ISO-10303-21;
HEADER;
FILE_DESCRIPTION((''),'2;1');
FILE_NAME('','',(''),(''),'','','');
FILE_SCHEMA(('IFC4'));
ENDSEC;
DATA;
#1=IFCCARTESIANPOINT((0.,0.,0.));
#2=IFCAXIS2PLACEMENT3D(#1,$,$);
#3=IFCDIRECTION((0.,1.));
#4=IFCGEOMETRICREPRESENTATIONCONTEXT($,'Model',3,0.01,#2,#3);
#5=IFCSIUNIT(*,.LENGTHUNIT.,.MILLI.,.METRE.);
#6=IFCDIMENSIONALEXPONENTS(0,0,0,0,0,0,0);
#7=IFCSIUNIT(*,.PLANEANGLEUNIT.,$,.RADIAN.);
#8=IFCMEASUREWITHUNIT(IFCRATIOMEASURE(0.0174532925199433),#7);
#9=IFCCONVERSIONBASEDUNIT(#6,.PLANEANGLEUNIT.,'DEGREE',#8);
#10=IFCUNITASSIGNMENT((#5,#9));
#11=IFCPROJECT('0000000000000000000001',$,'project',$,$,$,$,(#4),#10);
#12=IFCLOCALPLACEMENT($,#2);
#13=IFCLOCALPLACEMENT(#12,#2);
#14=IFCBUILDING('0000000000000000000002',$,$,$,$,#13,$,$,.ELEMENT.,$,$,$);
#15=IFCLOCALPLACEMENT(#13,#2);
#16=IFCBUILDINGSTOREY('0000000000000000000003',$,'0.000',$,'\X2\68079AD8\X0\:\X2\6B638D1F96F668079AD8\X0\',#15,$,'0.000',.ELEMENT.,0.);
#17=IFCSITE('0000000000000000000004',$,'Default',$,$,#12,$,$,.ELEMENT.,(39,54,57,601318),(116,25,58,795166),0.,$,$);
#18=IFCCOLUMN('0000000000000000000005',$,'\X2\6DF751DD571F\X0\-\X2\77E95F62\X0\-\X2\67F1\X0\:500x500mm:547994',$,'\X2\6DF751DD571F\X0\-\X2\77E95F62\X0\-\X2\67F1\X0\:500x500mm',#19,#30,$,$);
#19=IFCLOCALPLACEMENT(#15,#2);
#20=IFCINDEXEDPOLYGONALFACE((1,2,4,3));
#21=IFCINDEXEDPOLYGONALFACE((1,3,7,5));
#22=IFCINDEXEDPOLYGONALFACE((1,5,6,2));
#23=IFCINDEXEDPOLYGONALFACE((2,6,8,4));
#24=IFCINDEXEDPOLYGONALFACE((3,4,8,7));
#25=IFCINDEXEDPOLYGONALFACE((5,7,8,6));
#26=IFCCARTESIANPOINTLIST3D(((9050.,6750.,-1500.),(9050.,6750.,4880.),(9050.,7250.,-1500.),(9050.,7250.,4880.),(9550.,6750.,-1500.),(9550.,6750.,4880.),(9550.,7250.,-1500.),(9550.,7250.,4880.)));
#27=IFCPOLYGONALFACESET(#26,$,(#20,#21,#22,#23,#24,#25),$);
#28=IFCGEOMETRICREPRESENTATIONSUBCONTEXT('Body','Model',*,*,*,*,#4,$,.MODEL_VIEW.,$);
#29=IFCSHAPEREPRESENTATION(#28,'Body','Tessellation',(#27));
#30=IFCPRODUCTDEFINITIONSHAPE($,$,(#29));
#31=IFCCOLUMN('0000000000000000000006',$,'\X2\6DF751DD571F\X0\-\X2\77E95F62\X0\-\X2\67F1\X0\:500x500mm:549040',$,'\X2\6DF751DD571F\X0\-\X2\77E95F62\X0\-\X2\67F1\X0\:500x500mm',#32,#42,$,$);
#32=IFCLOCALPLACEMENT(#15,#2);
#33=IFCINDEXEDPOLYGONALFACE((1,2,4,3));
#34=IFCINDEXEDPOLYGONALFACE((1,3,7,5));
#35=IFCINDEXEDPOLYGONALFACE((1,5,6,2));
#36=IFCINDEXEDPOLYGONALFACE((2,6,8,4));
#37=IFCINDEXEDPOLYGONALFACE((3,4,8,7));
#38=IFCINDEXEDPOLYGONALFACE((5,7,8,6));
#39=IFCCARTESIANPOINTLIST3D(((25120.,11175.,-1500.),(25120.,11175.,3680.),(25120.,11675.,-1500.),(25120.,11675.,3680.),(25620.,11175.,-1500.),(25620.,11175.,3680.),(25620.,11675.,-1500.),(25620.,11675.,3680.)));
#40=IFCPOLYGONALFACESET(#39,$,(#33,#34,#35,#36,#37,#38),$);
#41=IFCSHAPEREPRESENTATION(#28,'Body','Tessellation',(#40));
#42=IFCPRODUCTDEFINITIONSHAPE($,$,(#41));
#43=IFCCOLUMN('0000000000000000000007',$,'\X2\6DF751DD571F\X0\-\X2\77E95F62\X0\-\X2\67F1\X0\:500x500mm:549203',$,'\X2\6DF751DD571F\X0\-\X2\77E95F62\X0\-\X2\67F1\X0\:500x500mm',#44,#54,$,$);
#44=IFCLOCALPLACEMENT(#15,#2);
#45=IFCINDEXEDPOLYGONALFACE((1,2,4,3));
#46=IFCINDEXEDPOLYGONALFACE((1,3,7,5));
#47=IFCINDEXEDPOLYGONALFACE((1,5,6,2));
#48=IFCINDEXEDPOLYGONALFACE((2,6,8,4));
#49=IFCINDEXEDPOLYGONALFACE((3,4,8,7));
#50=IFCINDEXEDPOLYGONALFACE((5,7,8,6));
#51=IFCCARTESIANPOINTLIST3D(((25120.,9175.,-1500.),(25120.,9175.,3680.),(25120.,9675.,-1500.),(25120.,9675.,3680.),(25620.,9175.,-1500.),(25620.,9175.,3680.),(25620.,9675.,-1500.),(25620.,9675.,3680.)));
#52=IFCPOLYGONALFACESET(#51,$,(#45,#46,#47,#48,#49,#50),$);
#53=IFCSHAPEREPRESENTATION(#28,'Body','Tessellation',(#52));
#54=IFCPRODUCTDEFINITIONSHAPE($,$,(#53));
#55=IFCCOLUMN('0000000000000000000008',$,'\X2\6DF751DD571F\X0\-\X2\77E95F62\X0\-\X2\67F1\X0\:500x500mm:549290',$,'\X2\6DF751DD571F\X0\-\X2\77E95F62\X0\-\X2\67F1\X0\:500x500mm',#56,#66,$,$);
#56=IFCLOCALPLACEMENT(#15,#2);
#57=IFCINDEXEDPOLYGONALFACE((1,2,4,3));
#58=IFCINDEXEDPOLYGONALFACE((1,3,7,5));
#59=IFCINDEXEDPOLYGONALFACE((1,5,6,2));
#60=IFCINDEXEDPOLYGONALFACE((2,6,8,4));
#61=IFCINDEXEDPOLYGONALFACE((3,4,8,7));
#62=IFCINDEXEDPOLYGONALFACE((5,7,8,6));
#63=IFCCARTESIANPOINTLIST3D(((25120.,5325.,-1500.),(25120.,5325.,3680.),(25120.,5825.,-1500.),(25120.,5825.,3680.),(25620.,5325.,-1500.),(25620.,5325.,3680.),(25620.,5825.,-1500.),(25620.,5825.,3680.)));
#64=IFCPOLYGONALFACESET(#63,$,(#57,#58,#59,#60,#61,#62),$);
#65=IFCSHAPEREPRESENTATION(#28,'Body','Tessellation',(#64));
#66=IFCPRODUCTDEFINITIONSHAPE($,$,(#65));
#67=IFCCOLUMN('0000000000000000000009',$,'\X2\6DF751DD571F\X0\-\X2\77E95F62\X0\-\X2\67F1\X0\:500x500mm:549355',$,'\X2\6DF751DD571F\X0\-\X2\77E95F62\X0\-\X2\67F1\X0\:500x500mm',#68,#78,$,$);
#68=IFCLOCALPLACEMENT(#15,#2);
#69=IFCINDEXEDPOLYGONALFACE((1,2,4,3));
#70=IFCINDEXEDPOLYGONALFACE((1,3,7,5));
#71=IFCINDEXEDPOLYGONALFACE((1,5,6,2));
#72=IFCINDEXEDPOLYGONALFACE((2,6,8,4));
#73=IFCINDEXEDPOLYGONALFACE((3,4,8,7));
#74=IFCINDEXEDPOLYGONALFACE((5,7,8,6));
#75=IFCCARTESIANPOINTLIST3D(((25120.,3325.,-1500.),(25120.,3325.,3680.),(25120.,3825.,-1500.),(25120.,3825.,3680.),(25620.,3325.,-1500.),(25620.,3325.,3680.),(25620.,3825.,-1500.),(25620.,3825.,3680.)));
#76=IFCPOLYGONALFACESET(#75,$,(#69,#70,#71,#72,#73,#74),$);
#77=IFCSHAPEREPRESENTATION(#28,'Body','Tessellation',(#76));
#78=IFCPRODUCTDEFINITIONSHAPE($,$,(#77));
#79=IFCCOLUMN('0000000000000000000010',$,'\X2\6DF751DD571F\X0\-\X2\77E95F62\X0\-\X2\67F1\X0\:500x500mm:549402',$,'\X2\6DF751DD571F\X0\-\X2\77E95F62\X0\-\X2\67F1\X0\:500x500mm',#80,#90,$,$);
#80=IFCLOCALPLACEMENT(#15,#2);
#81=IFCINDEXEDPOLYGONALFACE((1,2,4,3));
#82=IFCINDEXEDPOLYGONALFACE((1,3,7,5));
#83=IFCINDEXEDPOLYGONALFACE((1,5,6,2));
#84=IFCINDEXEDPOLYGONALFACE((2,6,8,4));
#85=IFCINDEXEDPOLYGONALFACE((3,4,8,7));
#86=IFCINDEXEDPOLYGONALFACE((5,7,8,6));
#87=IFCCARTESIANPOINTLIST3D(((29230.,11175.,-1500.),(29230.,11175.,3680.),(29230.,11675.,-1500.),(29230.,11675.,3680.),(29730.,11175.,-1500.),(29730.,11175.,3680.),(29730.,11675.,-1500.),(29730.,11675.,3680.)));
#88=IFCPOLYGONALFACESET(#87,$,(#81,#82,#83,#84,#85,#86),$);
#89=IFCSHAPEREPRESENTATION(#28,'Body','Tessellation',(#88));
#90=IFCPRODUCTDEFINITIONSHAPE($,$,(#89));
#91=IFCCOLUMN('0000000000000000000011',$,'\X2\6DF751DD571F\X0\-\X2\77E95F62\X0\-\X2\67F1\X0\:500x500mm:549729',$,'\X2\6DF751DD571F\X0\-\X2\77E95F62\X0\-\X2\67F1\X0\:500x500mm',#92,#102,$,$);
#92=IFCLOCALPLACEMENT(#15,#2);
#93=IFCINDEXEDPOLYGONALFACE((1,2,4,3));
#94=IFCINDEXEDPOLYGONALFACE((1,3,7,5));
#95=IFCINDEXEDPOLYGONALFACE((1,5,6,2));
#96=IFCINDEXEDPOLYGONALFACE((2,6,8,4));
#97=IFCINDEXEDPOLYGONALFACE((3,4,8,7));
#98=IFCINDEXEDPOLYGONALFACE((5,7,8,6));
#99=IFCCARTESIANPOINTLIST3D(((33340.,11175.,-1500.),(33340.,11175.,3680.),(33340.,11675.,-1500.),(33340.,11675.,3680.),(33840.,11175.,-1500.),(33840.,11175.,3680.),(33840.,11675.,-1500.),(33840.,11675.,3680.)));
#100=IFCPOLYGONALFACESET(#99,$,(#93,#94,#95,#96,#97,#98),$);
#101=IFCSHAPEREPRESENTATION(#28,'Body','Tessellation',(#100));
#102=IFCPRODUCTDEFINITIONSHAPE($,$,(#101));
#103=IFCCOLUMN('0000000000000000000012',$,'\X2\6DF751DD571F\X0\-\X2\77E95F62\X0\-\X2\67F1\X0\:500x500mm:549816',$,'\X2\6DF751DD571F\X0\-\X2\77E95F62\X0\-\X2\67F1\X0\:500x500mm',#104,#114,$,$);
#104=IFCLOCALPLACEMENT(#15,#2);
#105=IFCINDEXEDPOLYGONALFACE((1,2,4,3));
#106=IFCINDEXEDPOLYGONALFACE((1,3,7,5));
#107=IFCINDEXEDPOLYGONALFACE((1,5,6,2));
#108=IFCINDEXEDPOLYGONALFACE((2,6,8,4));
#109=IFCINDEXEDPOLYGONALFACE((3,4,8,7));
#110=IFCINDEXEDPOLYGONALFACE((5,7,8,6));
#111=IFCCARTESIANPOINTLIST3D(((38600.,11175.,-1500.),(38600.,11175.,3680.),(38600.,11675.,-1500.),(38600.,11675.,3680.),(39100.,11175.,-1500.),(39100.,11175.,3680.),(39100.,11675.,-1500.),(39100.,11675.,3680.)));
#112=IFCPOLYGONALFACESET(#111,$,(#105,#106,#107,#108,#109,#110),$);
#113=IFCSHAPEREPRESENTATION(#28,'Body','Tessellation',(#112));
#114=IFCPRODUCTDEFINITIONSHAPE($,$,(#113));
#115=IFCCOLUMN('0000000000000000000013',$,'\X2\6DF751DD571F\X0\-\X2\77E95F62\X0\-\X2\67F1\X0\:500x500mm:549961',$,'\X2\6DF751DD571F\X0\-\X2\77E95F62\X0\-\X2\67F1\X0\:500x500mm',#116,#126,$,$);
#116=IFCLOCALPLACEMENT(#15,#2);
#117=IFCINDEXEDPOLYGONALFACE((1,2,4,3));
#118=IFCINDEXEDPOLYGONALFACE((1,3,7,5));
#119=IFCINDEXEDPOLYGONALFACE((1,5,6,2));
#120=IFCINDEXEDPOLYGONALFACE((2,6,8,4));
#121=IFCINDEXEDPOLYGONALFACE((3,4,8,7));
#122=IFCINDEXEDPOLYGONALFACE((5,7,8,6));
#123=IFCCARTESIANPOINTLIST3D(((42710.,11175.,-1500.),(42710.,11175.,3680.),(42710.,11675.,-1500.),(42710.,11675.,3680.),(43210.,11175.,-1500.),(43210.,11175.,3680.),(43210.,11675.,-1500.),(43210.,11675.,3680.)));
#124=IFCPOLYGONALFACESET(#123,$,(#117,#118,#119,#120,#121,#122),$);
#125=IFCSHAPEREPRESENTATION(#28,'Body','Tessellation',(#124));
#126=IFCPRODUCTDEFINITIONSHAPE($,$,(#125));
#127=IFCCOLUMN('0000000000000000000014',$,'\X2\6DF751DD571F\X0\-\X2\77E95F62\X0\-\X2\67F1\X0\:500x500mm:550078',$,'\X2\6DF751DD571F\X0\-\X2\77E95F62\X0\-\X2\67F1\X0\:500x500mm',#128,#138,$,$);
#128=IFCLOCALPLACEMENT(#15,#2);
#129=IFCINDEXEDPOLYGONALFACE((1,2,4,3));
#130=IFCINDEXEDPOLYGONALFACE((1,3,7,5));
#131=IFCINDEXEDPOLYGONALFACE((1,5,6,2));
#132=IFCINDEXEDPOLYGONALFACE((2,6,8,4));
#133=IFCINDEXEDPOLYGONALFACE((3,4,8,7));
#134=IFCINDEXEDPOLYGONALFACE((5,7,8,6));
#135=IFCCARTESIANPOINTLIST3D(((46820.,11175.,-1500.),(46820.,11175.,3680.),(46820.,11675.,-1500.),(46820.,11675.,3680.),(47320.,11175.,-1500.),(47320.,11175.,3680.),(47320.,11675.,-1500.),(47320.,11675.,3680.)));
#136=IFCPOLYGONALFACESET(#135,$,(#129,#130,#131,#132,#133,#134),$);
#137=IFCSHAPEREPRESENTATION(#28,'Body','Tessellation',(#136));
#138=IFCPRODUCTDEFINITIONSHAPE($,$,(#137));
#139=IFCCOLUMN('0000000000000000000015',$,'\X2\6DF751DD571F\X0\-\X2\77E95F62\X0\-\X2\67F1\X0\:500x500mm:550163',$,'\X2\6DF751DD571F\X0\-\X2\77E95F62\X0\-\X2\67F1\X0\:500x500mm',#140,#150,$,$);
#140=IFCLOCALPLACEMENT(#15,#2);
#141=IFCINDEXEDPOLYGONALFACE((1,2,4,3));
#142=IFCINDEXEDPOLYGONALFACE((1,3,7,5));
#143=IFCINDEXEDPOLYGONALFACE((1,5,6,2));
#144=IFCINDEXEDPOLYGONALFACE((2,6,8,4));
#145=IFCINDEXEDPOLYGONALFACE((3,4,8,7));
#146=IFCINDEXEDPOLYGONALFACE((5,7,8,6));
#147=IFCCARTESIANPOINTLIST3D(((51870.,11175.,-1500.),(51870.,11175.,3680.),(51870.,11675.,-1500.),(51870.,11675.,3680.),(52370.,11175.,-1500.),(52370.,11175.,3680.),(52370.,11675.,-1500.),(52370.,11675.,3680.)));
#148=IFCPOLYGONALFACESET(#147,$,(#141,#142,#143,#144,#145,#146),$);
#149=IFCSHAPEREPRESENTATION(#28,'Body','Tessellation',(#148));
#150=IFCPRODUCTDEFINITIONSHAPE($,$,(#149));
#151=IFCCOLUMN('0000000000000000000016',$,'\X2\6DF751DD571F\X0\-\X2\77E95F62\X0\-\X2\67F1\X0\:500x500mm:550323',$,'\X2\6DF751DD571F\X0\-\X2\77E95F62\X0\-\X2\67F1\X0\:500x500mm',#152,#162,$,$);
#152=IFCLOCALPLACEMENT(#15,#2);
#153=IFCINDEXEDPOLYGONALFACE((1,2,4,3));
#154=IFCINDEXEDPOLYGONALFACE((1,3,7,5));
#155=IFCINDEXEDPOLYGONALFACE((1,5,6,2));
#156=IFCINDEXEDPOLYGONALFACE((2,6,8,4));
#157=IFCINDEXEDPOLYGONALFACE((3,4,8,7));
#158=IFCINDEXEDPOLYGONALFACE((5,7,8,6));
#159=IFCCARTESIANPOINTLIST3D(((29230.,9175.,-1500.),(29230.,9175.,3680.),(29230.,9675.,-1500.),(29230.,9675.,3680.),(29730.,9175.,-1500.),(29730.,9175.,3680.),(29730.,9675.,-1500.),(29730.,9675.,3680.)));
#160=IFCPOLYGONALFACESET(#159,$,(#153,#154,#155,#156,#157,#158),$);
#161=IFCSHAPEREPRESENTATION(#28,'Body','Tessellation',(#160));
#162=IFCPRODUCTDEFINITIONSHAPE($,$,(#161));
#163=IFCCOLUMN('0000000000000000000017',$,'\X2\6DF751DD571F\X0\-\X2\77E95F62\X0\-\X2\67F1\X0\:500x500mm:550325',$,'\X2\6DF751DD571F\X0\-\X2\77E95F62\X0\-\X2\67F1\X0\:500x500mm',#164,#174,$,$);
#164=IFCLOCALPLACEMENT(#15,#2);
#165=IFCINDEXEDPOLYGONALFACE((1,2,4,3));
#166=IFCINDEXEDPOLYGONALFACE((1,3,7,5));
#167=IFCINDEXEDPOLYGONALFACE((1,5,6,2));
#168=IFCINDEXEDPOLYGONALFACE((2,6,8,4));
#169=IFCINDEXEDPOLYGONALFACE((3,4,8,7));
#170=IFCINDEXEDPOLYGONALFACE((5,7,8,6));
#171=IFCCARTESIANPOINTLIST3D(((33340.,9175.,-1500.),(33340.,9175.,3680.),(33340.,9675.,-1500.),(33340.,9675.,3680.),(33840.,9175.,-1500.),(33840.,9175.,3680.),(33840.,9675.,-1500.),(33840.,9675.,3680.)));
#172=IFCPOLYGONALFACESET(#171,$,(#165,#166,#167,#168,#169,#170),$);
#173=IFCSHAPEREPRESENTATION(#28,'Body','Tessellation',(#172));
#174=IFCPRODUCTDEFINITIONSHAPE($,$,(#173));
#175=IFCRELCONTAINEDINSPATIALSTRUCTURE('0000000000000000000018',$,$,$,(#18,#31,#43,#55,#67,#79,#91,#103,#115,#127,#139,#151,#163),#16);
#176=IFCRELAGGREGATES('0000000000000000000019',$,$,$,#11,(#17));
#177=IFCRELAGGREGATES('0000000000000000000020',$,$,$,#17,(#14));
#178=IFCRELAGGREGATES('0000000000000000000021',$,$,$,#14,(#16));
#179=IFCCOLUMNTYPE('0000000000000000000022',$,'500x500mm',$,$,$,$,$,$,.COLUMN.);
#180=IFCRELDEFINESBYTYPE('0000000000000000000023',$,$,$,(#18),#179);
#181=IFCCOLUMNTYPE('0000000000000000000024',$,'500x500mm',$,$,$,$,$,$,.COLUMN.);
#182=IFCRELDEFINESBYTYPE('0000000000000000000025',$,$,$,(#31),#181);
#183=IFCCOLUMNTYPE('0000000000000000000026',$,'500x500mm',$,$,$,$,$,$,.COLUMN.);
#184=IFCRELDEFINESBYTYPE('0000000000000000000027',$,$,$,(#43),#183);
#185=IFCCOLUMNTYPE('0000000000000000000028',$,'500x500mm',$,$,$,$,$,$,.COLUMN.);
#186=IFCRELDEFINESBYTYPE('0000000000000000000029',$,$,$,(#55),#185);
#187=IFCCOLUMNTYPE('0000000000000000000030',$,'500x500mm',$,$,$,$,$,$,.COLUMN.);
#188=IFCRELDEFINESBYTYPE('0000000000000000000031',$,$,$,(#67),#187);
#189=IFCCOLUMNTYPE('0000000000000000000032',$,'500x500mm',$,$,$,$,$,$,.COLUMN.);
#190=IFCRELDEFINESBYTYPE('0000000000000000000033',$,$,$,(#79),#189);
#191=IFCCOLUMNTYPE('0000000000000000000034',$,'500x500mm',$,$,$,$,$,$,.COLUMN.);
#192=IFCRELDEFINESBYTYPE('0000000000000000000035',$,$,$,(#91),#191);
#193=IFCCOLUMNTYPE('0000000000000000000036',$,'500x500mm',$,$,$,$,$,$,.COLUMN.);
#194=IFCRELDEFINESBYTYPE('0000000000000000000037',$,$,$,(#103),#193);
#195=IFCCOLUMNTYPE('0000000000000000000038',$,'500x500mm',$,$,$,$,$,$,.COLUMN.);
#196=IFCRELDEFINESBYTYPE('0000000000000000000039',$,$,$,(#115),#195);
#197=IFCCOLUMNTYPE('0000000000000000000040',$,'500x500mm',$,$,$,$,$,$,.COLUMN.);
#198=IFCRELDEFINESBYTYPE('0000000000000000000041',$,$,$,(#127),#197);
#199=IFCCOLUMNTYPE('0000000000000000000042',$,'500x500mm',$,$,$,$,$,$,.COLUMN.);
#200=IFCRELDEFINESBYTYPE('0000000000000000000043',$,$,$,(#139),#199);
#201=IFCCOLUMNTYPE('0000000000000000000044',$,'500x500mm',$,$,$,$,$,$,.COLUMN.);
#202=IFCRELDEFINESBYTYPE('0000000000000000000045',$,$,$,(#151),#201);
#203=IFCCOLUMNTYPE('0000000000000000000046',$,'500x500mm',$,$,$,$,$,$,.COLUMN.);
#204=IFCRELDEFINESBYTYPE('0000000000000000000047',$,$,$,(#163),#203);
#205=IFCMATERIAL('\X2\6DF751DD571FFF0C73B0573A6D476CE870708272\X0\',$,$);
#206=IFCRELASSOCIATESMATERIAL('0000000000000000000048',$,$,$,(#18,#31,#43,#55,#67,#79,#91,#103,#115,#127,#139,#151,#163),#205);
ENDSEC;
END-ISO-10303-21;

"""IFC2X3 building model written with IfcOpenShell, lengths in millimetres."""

from ifc_helpers import new_model, entity, si_unit, converted_unit, direction, frame, frame_2d, origin, origin_2d_with_axis, place, context, subcontext, project, spatial, rectangle, extrude, source, transform, mapped, material, type_object, type_shapes, element, save


model = new_model("IFC2X3")

# Units and contexts
model_context = context("Model", 3, precision=0.01, world=origin(), true_north=direction((0.0, 1.0)))
body_context = subcontext(model_context, "Body", "Model", "MODEL_VIEW")
ifc_project = project(units=[si_unit("LENGTHUNIT", "METRE", prefix="MILLI"), converted_unit("PLANEANGLEUNIT", "DEGREE", entity("IfcRatioMeasure", 0.0174532925199433), si_unit("PLANEANGLEUNIT", "RADIAN"), dimensions=[0, 0, 0, 0, 0, 0, 0])], contexts=[model_context])

# Site, building, storey
site_placement = place(None, origin())
site = spatial("IfcSite", under=ifc_project, at=site_placement, Name="Default", CompositionType="ELEMENT", RefLatitude=(39, 54, 57, 601318), RefLongitude=(116, 25, 58, 795166), RefElevation=0.0)
building_placement = place(site_placement, origin())
building = spatial("IfcBuilding", under=site, at=building_placement, CompositionType="ELEMENT")
storey_placement = place(building_placement, origin())
storey = spatial("IfcBuildingStorey", under=building, at=storey_placement, Name="0.000", ObjectType="标高:正负零标高", LongName="0.000", CompositionType="ELEMENT", Elevation=0.0)

# Columns
ifc_material = material(Name="混凝土，现场浇注灰色")
column_type_1 = type_object("IfcColumnType", Name="500x500mm", PredefinedType="COLUMN")
shared_shape_1 = source(origin(), body_context, "Body", "SweptSolid", [
    extrude(rectangle(XDim=500.0, YDim=500.0, at=frame_2d((0.0, 0.0), x_axis=(1.0, 0.0))), frame((9300.0, 7000.0, -1500.0), z_axis=(0.0, 0.0, 1.0), x_axis=(0.0, -1.0, 0.0)), (0.0, 0.0, 1.0), 6380.0),
])
type_shapes(column_type_1, [shared_shape_1])
column_1_placement = place(storey_placement, origin())
element("IfcColumn", 1, at=column_1_placement, inside=storey, type_object=column_type_1, material=ifc_material, Name="混凝土-矩形-柱:500x500mm:547994", ObjectType="混凝土-矩形-柱:500x500mm", context=body_context, shape_type="MappedRepresentation", body=[
    mapped(shared_shape_1, transform((0.0, 0.0, 0.0), scale=1.0)),
])
column_type_2 = type_object("IfcColumnType", Name="500x500mm", PredefinedType="COLUMN")
shared_shape_2 = source(origin(), body_context, "Body", "SweptSolid", [
    extrude(rectangle(XDim=500.0, YDim=500.0, at=origin_2d_with_axis()), frame((25370.0, 11425.0, -1500.0), z_axis=(0.0, 0.0, 1.0), x_axis=(0.0, -1.0, 0.0)), (0.0, 0.0, 1.0), 5180.0),
])
type_shapes(column_type_2, [shared_shape_2])
column_2_placement = place(storey_placement, origin())
element("IfcColumn", 2, at=column_2_placement, inside=storey, type_object=column_type_2, material=ifc_material, Name="混凝土-矩形-柱:500x500mm:549040", ObjectType="混凝土-矩形-柱:500x500mm", context=body_context, shape_type="MappedRepresentation", body=[
    mapped(shared_shape_2, transform((0.0, 0.0, 0.0), scale=1.0)),
])
column_type_3 = type_object("IfcColumnType", Name="500x500mm", PredefinedType="COLUMN")
shared_shape_3 = source(origin(), body_context, "Body", "SweptSolid", [
    extrude(rectangle(XDim=500.0, YDim=500.0, at=frame_2d((0.0, 0.0), x_axis=(1.0, 0.0))), frame((25370.0, 9425.0, -1500.0), z_axis=(0.0, 0.0, 1.0), x_axis=(0.0, -1.0, 0.0)), (0.0, 0.0, 1.0), 5180.0),
])
type_shapes(column_type_3, [shared_shape_3])
column_3_placement = place(storey_placement, origin())
element("IfcColumn", 3, at=column_3_placement, inside=storey, type_object=column_type_3, material=ifc_material, Name="混凝土-矩形-柱:500x500mm:549203", ObjectType="混凝土-矩形-柱:500x500mm", context=body_context, shape_type="MappedRepresentation", body=[
    mapped(shared_shape_3, transform((0.0, 0.0, 0.0), scale=1.0)),
])
column_type_4 = type_object("IfcColumnType", Name="500x500mm", PredefinedType="COLUMN")
shared_shape_4 = source(origin(), body_context, "Body", "SweptSolid", [
    extrude(rectangle(XDim=500.0, YDim=500.0, at=origin_2d_with_axis()), frame((25370.0, 5575.0, -1500.0), z_axis=(0.0, 0.0, 1.0), x_axis=(0.0, -1.0, 0.0)), (0.0, 0.0, 1.0), 5180.0),
])
type_shapes(column_type_4, [shared_shape_4])
column_4_placement = place(storey_placement, origin())
element("IfcColumn", 4, at=column_4_placement, inside=storey, type_object=column_type_4, material=ifc_material, Name="混凝土-矩形-柱:500x500mm:549290", ObjectType="混凝土-矩形-柱:500x500mm", context=body_context, shape_type="MappedRepresentation", body=[
    mapped(shared_shape_4, transform((0.0, 0.0, 0.0), scale=1.0)),
])
column_type_5 = type_object("IfcColumnType", Name="500x500mm", PredefinedType="COLUMN")
shared_shape_5 = source(origin(), body_context, "Body", "SweptSolid", [
    extrude(rectangle(XDim=500.0, YDim=500.0, at=origin_2d_with_axis()), frame((25370.0, 3575.0, -1500.0), z_axis=(0.0, 0.0, 1.0), x_axis=(0.0, -1.0, 0.0)), (0.0, 0.0, 1.0), 5180.0),
])
type_shapes(column_type_5, [shared_shape_5])
column_5_placement = place(storey_placement, origin())
element("IfcColumn", 5, at=column_5_placement, inside=storey, type_object=column_type_5, material=ifc_material, Name="混凝土-矩形-柱:500x500mm:549355", ObjectType="混凝土-矩形-柱:500x500mm", context=body_context, shape_type="MappedRepresentation", body=[
    mapped(shared_shape_5, transform((0.0, 0.0, 0.0), scale=1.0)),
])
column_type_6 = type_object("IfcColumnType", Name="500x500mm", PredefinedType="COLUMN")
shared_shape_6 = source(origin(), body_context, "Body", "SweptSolid", [
    extrude(rectangle(XDim=500.0, YDim=500.0, at=origin_2d_with_axis()), frame((29480.0, 11425.0, -1500.0), z_axis=(0.0, 0.0, 1.0), x_axis=(0.0, -1.0, 0.0)), (0.0, 0.0, 1.0), 5180.0),
])
type_shapes(column_type_6, [shared_shape_6])
column_6_placement = place(storey_placement, origin())
element("IfcColumn", 6, at=column_6_placement, inside=storey, type_object=column_type_6, material=ifc_material, Name="混凝土-矩形-柱:500x500mm:549402", ObjectType="混凝土-矩形-柱:500x500mm", context=body_context, shape_type="MappedRepresentation", body=[
    mapped(shared_shape_6, transform((0.0, 0.0, 0.0), scale=1.0)),
])
column_type_7 = type_object("IfcColumnType", Name="500x500mm", PredefinedType="COLUMN")
shared_shape_7 = source(origin(), body_context, "Body", "SweptSolid", [
    extrude(rectangle(XDim=500.0, YDim=500.0, at=origin_2d_with_axis()), frame((33590.0, 11425.0, -1500.0), z_axis=(0.0, 0.0, 1.0), x_axis=(0.0, -1.0, 0.0)), (0.0, 0.0, 1.0), 5180.0),
])
type_shapes(column_type_7, [shared_shape_7])
column_7_placement = place(storey_placement, origin())
element("IfcColumn", 7, at=column_7_placement, inside=storey, type_object=column_type_7, material=ifc_material, Name="混凝土-矩形-柱:500x500mm:549729", ObjectType="混凝土-矩形-柱:500x500mm", context=body_context, shape_type="MappedRepresentation", body=[
    mapped(shared_shape_7, transform((0.0, 0.0, 0.0), scale=1.0)),
])
column_type_8 = type_object("IfcColumnType", Name="500x500mm", PredefinedType="COLUMN")
shared_shape_8 = source(origin(), body_context, "Body", "SweptSolid", [
    extrude(rectangle(XDim=500.0, YDim=500.0, at=frame_2d((0.0, 0.0), x_axis=(1.0, 0.0))), frame((38850.0, 11425.0, -1500.0), z_axis=(0.0, 0.0, 1.0), x_axis=(0.0, -1.0, 0.0)), (0.0, 0.0, 1.0), 5180.0),
])
type_shapes(column_type_8, [shared_shape_8])
column_8_placement = place(storey_placement, origin())
element("IfcColumn", 8, at=column_8_placement, inside=storey, type_object=column_type_8, material=ifc_material, Name="混凝土-矩形-柱:500x500mm:549816", ObjectType="混凝土-矩形-柱:500x500mm", context=body_context, shape_type="MappedRepresentation", body=[
    mapped(shared_shape_8, transform((0.0, 0.0, 0.0), scale=1.0)),
])
column_type_9 = type_object("IfcColumnType", Name="500x500mm", PredefinedType="COLUMN")
shared_shape_9 = source(origin(), body_context, "Body", "SweptSolid", [
    extrude(rectangle(XDim=500.0, YDim=500.0, at=origin_2d_with_axis()), frame((42960.0, 11425.0, -1500.0), z_axis=(0.0, 0.0, 1.0), x_axis=(0.0, -1.0, 0.0)), (0.0, 0.0, 1.0), 5180.0),
])
type_shapes(column_type_9, [shared_shape_9])
column_9_placement = place(storey_placement, origin())
element("IfcColumn", 9, at=column_9_placement, inside=storey, type_object=column_type_9, material=ifc_material, Name="混凝土-矩形-柱:500x500mm:549961", ObjectType="混凝土-矩形-柱:500x500mm", context=body_context, shape_type="MappedRepresentation", body=[
    mapped(shared_shape_9, transform((0.0, 0.0, 0.0), scale=1.0)),
])
column_type_10 = type_object("IfcColumnType", Name="500x500mm", PredefinedType="COLUMN")
shared_shape_10 = source(origin(), body_context, "Body", "SweptSolid", [
    extrude(rectangle(XDim=500.0, YDim=500.0, at=origin_2d_with_axis()), frame((47070.0, 11425.0, -1500.0), z_axis=(0.0, 0.0, 1.0), x_axis=(0.0, -1.0, 0.0)), (0.0, 0.0, 1.0), 5180.0),
])
type_shapes(column_type_10, [shared_shape_10])
column_10_placement = place(storey_placement, origin())
element("IfcColumn", 10, at=column_10_placement, inside=storey, type_object=column_type_10, material=ifc_material, Name="混凝土-矩形-柱:500x500mm:550078", ObjectType="混凝土-矩形-柱:500x500mm", context=body_context, shape_type="MappedRepresentation", body=[
    mapped(shared_shape_10, transform((0.0, 0.0, 0.0), scale=1.0)),
])
column_type_11 = type_object("IfcColumnType", Name="500x500mm", PredefinedType="COLUMN")
shared_shape_11 = source(origin(), body_context, "Body", "SweptSolid", [
    extrude(rectangle(XDim=500.0, YDim=500.0, at=frame_2d((0.0, 0.0), x_axis=(1.0, 0.0))), frame((52120.0, 11425.0, -1500.0), z_axis=(0.0, 0.0, 1.0), x_axis=(0.0, -1.0, 0.0)), (0.0, 0.0, 1.0), 5180.0),
])
type_shapes(column_type_11, [shared_shape_11])
column_11_placement = place(storey_placement, origin())
element("IfcColumn", 11, at=column_11_placement, inside=storey, type_object=column_type_11, material=ifc_material, Name="混凝土-矩形-柱:500x500mm:550163", ObjectType="混凝土-矩形-柱:500x500mm", context=body_context, shape_type="MappedRepresentation", body=[
    mapped(shared_shape_11, transform((0.0, 0.0, 0.0), scale=1.0)),
])
column_type_12 = type_object("IfcColumnType", Name="500x500mm", PredefinedType="COLUMN")
shared_shape_12 = source(origin(), body_context, "Body", "SweptSolid", [
    extrude(rectangle(XDim=500.0, YDim=500.0, at=origin_2d_with_axis()), frame((29480.0, 9425.0, -1500.0), z_axis=(0.0, 0.0, 1.0), x_axis=(0.0, -1.0, 0.0)), (0.0, 0.0, 1.0), 5180.0),
])
type_shapes(column_type_12, [shared_shape_12])
column_12_placement = place(storey_placement, origin())
element("IfcColumn", 12, at=column_12_placement, inside=storey, type_object=column_type_12, material=ifc_material, Name="混凝土-矩形-柱:500x500mm:550323", ObjectType="混凝土-矩形-柱:500x500mm", context=body_context, shape_type="MappedRepresentation", body=[
    mapped(shared_shape_12, transform((0.0, 0.0, 0.0), scale=1.0)),
])
column_type_13 = type_object("IfcColumnType", Name="500x500mm", PredefinedType="COLUMN")
shared_shape_13 = source(origin(), body_context, "Body", "SweptSolid", [
    extrude(rectangle(XDim=500.0, YDim=500.0, at=origin_2d_with_axis()), frame((33590.0, 9425.0, -1500.0), z_axis=(0.0, 0.0, 1.0), x_axis=(0.0, -1.0, 0.0)), (0.0, 0.0, 1.0), 5180.0),
])
type_shapes(column_type_13, [shared_shape_13])
column_13_placement = place(storey_placement, origin())
element("IfcColumn", 13, at=column_13_placement, inside=storey, type_object=column_type_13, material=ifc_material, Name="混凝土-矩形-柱:500x500mm:550325", ObjectType="混凝土-矩形-柱:500x500mm", context=body_context, shape_type="MappedRepresentation", body=[
    mapped(shared_shape_13, transform((0.0, 0.0, 0.0), scale=1.0)),
])

save(model, "model.ifc")
